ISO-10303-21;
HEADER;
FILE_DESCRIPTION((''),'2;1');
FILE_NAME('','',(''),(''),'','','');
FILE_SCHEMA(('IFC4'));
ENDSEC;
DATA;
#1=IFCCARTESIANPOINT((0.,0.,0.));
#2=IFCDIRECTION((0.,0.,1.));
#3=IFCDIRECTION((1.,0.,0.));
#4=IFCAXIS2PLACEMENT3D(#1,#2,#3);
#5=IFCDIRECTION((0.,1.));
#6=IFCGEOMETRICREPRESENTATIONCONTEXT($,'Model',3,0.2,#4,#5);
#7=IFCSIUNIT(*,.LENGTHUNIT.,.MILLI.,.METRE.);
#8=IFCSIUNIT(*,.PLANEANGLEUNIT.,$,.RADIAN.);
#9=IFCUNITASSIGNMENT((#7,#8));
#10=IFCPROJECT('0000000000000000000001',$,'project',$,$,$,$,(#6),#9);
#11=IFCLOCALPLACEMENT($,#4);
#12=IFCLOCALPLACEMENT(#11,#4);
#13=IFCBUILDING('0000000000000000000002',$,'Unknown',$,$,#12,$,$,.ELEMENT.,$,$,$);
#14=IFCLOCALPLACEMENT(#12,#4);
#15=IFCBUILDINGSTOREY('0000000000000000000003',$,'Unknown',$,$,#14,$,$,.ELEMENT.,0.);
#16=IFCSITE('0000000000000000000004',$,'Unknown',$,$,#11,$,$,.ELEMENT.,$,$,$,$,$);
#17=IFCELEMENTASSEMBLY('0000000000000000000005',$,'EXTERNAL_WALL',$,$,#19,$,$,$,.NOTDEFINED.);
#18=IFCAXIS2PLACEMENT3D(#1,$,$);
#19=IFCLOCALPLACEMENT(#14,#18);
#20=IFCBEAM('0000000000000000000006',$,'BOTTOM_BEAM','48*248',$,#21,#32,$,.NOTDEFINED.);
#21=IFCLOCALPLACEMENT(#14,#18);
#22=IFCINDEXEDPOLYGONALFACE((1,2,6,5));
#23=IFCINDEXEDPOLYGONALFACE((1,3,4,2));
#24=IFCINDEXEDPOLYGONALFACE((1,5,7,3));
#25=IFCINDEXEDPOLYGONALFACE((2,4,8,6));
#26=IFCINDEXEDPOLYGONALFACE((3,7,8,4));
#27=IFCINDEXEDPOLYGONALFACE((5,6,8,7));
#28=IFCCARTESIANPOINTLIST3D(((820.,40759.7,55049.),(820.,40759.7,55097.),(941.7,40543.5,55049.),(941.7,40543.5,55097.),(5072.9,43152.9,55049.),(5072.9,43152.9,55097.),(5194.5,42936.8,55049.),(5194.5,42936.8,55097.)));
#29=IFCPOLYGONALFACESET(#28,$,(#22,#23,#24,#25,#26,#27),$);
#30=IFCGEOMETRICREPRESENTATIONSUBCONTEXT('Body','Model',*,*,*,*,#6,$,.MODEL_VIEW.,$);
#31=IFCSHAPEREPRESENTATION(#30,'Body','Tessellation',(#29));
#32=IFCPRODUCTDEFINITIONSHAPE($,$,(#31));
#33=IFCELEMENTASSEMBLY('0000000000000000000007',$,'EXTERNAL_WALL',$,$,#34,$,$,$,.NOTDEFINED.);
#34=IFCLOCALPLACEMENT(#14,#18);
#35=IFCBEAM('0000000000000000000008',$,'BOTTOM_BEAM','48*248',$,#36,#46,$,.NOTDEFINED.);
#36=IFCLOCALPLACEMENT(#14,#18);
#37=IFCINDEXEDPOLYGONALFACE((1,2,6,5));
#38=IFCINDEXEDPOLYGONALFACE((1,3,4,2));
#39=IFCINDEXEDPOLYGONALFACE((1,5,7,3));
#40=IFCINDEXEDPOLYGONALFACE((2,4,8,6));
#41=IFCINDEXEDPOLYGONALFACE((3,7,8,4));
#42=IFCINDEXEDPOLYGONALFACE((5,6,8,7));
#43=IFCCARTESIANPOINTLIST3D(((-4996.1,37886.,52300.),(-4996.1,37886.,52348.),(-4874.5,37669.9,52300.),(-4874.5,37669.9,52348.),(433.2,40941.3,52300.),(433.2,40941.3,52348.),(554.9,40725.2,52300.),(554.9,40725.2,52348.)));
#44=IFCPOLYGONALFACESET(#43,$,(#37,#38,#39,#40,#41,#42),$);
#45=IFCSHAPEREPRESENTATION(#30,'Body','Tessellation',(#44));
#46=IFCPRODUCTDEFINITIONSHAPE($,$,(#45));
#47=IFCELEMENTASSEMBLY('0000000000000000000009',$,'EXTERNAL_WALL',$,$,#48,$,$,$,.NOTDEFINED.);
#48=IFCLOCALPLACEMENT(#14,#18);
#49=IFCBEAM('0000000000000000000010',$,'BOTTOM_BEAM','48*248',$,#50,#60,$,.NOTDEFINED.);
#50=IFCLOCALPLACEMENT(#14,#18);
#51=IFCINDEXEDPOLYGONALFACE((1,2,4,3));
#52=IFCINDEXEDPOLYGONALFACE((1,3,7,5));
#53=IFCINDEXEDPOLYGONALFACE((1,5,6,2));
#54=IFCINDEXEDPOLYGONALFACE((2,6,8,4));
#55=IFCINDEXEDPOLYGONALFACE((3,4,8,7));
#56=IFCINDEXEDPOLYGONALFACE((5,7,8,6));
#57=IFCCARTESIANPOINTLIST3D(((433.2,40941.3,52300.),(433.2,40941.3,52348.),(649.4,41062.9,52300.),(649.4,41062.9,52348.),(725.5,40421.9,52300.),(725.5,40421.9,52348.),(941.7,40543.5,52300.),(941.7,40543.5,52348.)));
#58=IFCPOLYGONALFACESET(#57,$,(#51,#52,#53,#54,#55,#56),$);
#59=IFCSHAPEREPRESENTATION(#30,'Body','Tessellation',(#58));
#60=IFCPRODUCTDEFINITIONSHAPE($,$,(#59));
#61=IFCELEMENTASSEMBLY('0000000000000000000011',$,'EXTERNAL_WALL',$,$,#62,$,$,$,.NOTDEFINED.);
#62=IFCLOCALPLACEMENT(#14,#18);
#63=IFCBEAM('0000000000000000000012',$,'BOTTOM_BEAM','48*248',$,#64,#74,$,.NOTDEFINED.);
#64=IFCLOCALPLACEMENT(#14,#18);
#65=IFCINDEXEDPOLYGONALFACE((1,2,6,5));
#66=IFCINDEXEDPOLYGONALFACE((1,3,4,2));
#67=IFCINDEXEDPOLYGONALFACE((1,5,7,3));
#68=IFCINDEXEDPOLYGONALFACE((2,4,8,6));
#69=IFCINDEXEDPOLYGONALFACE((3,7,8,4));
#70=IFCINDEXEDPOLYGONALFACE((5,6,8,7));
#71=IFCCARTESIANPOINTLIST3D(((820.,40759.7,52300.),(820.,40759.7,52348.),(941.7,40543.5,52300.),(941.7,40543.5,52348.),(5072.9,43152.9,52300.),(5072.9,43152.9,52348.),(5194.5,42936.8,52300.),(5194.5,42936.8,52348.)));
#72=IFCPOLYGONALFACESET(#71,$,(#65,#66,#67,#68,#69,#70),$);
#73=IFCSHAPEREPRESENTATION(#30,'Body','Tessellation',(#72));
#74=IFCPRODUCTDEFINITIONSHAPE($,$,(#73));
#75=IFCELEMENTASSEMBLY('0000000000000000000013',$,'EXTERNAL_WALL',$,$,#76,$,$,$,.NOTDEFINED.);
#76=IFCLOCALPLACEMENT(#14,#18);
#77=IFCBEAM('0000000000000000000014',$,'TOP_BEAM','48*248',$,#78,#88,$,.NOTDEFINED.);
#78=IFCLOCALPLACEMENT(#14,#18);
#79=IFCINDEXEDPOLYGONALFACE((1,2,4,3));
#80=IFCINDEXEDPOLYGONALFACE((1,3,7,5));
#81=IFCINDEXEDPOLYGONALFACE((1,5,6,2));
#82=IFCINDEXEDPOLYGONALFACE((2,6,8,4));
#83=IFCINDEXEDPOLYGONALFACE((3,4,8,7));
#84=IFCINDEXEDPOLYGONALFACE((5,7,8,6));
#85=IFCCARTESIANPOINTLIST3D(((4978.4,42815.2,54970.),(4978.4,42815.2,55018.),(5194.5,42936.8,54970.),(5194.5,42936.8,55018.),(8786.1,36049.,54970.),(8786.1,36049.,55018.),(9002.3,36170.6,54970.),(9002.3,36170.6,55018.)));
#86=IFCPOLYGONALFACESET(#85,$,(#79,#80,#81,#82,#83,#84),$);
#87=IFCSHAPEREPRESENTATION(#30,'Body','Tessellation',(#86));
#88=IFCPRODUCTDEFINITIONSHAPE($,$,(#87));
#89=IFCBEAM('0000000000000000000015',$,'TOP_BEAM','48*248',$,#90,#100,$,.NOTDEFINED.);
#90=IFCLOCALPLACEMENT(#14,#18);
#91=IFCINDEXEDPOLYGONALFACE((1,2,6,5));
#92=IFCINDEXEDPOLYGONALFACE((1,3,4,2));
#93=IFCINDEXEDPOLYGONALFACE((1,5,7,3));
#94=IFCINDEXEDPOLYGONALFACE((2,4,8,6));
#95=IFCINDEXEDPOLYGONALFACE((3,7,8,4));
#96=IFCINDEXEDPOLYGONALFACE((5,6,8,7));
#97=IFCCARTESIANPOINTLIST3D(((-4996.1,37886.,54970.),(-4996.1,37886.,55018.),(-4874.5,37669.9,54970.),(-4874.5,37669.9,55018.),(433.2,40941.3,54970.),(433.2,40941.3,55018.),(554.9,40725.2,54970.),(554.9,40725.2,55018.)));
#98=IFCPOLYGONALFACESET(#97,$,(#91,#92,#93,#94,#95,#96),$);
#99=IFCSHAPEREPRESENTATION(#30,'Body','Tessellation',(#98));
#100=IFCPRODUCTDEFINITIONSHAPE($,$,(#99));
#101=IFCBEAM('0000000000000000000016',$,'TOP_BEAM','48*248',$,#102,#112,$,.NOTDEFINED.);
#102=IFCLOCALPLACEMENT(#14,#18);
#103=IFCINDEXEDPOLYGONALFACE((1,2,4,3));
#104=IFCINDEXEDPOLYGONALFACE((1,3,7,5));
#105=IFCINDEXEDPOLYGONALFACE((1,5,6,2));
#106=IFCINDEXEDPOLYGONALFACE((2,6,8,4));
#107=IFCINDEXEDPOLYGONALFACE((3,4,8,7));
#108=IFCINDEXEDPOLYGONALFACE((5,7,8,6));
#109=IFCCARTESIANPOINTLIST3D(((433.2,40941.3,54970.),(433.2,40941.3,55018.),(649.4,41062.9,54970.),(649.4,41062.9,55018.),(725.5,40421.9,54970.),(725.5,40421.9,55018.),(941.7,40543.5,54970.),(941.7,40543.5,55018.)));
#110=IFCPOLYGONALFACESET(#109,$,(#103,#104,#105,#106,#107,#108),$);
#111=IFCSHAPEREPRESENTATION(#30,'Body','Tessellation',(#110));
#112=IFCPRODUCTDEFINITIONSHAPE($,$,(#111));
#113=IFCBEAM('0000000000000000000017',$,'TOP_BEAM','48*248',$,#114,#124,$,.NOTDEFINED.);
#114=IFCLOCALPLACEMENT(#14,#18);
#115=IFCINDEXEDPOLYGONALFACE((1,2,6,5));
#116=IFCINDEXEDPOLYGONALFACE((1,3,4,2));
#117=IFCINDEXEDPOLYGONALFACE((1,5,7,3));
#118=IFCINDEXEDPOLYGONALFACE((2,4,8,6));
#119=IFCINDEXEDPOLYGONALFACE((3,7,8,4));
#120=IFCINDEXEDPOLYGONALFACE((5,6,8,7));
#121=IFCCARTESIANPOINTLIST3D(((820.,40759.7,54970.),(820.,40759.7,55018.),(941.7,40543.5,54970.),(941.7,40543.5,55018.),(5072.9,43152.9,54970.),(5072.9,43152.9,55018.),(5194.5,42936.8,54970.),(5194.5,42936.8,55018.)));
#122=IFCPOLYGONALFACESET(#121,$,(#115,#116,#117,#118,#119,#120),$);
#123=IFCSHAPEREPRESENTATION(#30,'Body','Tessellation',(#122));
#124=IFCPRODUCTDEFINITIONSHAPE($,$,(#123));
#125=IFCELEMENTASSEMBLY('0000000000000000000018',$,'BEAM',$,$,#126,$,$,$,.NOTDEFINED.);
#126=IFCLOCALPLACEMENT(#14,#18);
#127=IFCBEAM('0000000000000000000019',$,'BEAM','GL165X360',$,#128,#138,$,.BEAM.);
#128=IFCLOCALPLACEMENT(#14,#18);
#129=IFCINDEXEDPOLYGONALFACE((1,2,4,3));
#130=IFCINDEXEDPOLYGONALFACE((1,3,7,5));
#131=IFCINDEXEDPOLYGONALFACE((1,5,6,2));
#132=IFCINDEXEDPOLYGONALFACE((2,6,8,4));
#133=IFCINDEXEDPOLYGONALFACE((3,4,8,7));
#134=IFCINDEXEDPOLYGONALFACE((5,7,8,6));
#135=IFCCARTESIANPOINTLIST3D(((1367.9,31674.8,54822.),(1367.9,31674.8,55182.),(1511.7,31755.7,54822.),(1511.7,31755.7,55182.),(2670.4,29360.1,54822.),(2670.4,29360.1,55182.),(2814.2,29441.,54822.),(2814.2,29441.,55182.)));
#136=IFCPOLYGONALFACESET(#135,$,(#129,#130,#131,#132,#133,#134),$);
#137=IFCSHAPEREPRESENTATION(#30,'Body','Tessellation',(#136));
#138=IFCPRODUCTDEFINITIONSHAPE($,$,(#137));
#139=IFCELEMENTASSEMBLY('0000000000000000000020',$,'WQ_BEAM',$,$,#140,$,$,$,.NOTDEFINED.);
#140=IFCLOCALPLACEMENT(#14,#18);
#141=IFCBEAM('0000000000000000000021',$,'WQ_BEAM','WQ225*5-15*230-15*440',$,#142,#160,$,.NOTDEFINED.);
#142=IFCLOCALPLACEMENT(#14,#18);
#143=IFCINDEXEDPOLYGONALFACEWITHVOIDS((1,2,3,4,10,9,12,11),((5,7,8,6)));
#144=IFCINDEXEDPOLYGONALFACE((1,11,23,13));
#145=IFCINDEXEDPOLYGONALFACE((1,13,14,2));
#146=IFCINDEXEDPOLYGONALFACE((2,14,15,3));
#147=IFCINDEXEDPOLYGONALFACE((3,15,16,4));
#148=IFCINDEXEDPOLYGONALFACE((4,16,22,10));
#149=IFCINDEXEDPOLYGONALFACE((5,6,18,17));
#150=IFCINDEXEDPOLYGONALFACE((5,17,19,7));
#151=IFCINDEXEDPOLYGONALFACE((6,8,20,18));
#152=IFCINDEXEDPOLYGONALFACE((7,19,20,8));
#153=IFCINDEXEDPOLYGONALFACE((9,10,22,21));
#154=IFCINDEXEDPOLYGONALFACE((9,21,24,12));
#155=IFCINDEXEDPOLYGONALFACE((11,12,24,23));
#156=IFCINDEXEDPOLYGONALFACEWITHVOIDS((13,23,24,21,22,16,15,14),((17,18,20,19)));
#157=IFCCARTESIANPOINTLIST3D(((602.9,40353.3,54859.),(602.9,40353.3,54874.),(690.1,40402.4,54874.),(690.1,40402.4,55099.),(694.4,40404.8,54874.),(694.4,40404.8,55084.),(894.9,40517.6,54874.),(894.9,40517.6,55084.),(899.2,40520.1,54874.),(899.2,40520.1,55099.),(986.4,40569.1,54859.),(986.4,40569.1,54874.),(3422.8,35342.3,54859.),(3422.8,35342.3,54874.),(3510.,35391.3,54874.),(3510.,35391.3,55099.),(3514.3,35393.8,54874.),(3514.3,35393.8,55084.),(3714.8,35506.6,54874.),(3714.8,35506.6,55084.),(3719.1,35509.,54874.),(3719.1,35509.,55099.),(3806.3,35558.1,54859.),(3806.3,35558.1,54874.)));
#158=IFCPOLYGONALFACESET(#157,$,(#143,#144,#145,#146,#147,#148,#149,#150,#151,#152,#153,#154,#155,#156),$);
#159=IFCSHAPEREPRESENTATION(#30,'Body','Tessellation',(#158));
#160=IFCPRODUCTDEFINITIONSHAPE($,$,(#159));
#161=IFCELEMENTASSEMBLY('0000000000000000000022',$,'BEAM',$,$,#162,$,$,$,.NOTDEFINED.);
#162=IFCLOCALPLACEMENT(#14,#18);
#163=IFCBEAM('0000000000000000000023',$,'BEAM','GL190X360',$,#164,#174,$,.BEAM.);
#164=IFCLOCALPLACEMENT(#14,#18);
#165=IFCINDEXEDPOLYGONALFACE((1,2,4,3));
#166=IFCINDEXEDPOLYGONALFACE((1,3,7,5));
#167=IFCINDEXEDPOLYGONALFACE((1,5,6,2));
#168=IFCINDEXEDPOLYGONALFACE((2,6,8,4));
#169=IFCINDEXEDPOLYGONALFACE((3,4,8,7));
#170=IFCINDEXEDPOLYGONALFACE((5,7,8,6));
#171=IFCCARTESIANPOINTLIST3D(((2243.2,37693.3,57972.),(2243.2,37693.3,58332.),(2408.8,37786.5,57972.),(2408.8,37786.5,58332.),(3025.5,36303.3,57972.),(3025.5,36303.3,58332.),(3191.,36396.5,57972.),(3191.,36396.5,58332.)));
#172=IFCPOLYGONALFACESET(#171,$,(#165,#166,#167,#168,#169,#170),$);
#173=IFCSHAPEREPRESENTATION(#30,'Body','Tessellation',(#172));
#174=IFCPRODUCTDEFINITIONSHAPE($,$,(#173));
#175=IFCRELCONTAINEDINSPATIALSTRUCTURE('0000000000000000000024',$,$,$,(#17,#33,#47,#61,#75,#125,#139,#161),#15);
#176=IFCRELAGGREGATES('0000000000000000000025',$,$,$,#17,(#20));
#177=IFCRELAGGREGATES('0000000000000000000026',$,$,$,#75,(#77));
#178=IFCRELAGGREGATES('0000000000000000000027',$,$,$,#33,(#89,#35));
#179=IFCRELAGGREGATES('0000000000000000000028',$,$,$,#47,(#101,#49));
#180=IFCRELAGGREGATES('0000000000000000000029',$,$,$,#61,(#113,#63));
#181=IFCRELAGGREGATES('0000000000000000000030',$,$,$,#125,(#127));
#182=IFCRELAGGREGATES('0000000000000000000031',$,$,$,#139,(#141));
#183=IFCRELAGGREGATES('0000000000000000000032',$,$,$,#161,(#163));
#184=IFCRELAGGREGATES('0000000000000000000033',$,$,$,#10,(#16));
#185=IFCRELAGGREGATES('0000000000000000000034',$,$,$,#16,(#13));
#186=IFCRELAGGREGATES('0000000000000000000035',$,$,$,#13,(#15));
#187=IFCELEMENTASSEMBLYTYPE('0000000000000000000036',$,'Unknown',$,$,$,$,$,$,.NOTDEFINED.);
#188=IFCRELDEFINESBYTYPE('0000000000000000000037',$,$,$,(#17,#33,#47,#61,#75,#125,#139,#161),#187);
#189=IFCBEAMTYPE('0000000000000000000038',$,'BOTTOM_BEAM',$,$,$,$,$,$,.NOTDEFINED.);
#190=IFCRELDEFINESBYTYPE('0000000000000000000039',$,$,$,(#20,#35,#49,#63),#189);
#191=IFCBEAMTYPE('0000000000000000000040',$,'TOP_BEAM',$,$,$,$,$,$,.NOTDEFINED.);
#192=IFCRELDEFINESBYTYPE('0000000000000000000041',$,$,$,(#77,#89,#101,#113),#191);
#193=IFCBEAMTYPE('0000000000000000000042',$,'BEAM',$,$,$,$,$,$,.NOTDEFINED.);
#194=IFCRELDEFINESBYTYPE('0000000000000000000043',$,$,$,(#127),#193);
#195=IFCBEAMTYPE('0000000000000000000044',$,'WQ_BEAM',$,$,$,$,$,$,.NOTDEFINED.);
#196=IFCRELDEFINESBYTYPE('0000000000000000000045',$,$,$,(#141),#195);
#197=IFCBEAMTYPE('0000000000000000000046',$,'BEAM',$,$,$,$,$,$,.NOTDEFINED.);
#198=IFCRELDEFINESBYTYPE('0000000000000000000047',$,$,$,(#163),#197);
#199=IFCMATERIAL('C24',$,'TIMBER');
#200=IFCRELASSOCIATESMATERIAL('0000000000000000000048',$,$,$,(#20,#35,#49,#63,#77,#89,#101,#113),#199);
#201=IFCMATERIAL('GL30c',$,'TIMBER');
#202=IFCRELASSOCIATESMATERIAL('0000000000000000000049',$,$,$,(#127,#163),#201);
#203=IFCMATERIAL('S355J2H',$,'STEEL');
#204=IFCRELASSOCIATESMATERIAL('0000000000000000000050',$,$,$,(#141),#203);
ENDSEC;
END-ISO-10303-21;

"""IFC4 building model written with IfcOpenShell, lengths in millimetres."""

from ifc_helpers import new_model, si_unit, direction, frame, origin_with_axes, origin_2d_with_axis, place, context, subcontext, project, spatial, polyline, rectangle, outline, extrude, material, material_profile, profile_set, profile_usage, type_object, element, aggregate, save


model = new_model("IFC4")

# Units and contexts
model_context = context("Model", 3, precision=0.2, world=origin_with_axes(), true_north=direction((0.0, 1.0)))
body_context = subcontext(model_context, "Body", "Model", "MODEL_VIEW")
ifc_project = project(units=[si_unit("LENGTHUNIT", "METRE", prefix="MILLI"), si_unit("PLANEANGLEUNIT", "RADIAN")], contexts=[model_context])

# Site, building, storey
site_placement = place(None, origin_with_axes())
site = spatial("IfcSite", under=ifc_project, at=site_placement, Name="Unknown", CompositionType="ELEMENT")
building_placement = place(site_placement, origin_with_axes())
building = spatial("IfcBuilding", under=site, at=building_placement, Name="Unknown", CompositionType="ELEMENT")
storey_placement = place(building_placement, origin_with_axes())
storey = spatial("IfcBuildingStorey", under=building, at=storey_placement, Name="Unknown", CompositionType="ELEMENT", Elevation=0.0)

# Shared definitions
element_assembly_type = type_object("IfcElementAssemblyType", Name="Unknown", PredefinedType="NOTDEFINED")

# Shared definitions
ifc_material_1 = material(Name="S355J2H", Category="STEEL")
ifc_material_2 = material(Name="GL30c", Category="TIMBER")

# Element assemblies, beams
ifc_material_3 = material(Name="C24", Category="TIMBER")
ifc_material_profile_1 = material_profile(ifc_material_3, rectangle(XDim=248.0, YDim=48.0, at=origin_2d_with_axis()), Name="48*248")
ifc_profile_set_1 = profile_set([ifc_material_profile_1])
ifc_profile_usage_1 = profile_usage(ifc_profile_set_1, cardinal=3)
beam_type_1 = type_object("IfcBeamType", Name="BOTTOM_BEAM")
assembly_1_placement = place(storey_placement, frame((880.9, 40651.6, 58308.0), z_axis=(0.490421, -0.871485, 0.0), x_axis=(0.871484, 0.490423, 0.0)))
assembly_1 = element("IfcElementAssembly", 1, at=assembly_1_placement, inside=storey, type_object=element_assembly_type, Name="EXTERNAL_WALL", PredefinedType="NOTDEFINED")
beam_1_placement = place(assembly_1_placement, frame((0.0, -3235.0, 0.0), z_axis=(0.0, 0.0, 1.0), x_axis=(1.0, 0.0, 0.0)))
beam_1 = element("IfcBeam", 2, at=beam_1_placement, type_object=beam_type_1, material=ifc_profile_usage_1, Name="BOTTOM_BEAM", Description="48*248", PredefinedType="NOTDEFINED", context=body_context, shape_type="SolidModel", body=[
    extrude(rectangle(XDim=248.0, YDim=48.0, at=origin_2d_with_axis()), frame((0.0, 0.0, 0.0), z_axis=(-1.0, 0.0, 0.0), x_axis=(0.0, 0.0, 1.0)), (0.0, 0.0, -1.0), 4880.0),
])
aggregate(assembly_1, [beam_1])
assembly_2_placement = place(storey_placement, frame((-4935.3, 37777.9, 54994.0), z_axis=(0.490421, -0.871485, 0.0), x_axis=(0.871484, 0.490423, 0.0)))
assembly_2 = element("IfcElementAssembly", 3, at=assembly_2_placement, inside=storey, type_object=element_assembly_type, Name="EXTERNAL_WALL", PredefinedType="NOTDEFINED")
beam_2_placement = place(assembly_2_placement, frame((0.0, -2670.0, 0.0), z_axis=(0.0, 0.0, 1.0), x_axis=(1.0, 0.0, 0.0)))
beam_2 = element("IfcBeam", 4, at=beam_2_placement, type_object=beam_type_1, material=ifc_profile_usage_1, Name="BOTTOM_BEAM", Description="48*248", PredefinedType="NOTDEFINED", context=body_context, shape_type="SolidModel", body=[
    extrude(rectangle(XDim=248.0, YDim=48.0, at=origin_2d_with_axis()), frame((0.0, 0.0, 0.0), z_axis=(-1.0, 0.0, 0.0), x_axis=(0.0, 0.0, 1.0)), (0.0, 0.0, -1.0), 6230.0),
])
assembly_3_placement = place(storey_placement, frame((541.3, 41002.1, 54994.0), z_axis=(-0.871487, -0.490418, 0.0), x_axis=(0.490421, -0.871485, 0.0)))
assembly_3 = element("IfcElementAssembly", 5, at=assembly_3_placement, inside=storey, type_object=element_assembly_type, Name="EXTERNAL_WALL", PredefinedType="NOTDEFINED")
beam_3_placement = place(assembly_3_placement, frame((0.0, -2670.0, 0.0), z_axis=(0.0, 0.0, 1.0), x_axis=(1.0, 0.0, 0.0)))
beam_3 = element("IfcBeam", 6, at=beam_3_placement, type_object=beam_type_1, material=ifc_profile_usage_1, Name="BOTTOM_BEAM", Description="48*248", PredefinedType="NOTDEFINED", context=body_context, shape_type="SolidModel", body=[
    extrude(rectangle(XDim=248.0, YDim=48.0, at=origin_2d_with_axis()), frame((0.0, 0.0, 0.0), z_axis=(-1.0, 0.0, 0.0), x_axis=(0.0, 0.0, 1.0)), (0.0, 0.0, -1.0), 596.0),
])
assembly_4_placement = place(storey_placement, frame((880.9, 40651.6, 54994.0), z_axis=(0.490421, -0.871485, 0.0), x_axis=(0.871484, 0.490423, 0.0)))
assembly_4 = element("IfcElementAssembly", 7, at=assembly_4_placement, inside=storey, type_object=element_assembly_type, Name="EXTERNAL_WALL", PredefinedType="NOTDEFINED")
beam_4_placement = place(assembly_4_placement, frame((0.0, -2670.0, 0.0), z_axis=(0.0, 0.0, 1.0), x_axis=(1.0, 0.0, 0.0)))
beam_4 = element("IfcBeam", 8, at=beam_4_placement, type_object=beam_type_1, material=ifc_profile_usage_1, Name="BOTTOM_BEAM", Description="48*248", PredefinedType="NOTDEFINED", context=body_context, shape_type="SolidModel", body=[
    extrude(rectangle(XDim=248.0, YDim=48.0, at=origin_2d_with_axis()), frame((0.0, 0.0, 0.0), z_axis=(-1.0, 0.0, 0.0), x_axis=(0.0, 0.0, 1.0)), (0.0, 0.0, -1.0), 4880.0),
])
assembly_5_placement = place(storey_placement, frame((5086.5, 42876.0, 54994.0), z_axis=(-0.871477, -0.490436, 0.0), x_axis=(0.490442, -0.871474, 0.0)))
assembly_5 = element("IfcElementAssembly", 9, at=assembly_5_placement, inside=storey, type_object=element_assembly_type, Name="EXTERNAL_WALL", PredefinedType="NOTDEFINED")
beam_type_2 = type_object("IfcBeamType", Name="TOP_BEAM")
beam_5_placement = place(assembly_5_placement, origin_with_axes())
beam_5 = element("IfcBeam", 10, at=beam_5_placement, type_object=beam_type_2, material=ifc_profile_usage_1, Name="TOP_BEAM", Description="48*248", PredefinedType="NOTDEFINED", context=body_context, shape_type="SolidModel", body=[
    extrude(rectangle(XDim=248.0, YDim=48.0, at=origin_2d_with_axis()), frame((0.0, 0.0, 0.0), z_axis=(-1.0, 0.0, 0.0), x_axis=(0.0, 0.0, 1.0)), (0.0, 0.0, -1.0), 7764.0),
])
aggregate(assembly_5, [beam_5])

# Beams
beam_6_placement = place(assembly_2_placement, origin_with_axes())
beam_6 = element("IfcBeam", 11, at=beam_6_placement, type_object=beam_type_2, material=ifc_profile_usage_1, Name="TOP_BEAM", Description="48*248", PredefinedType="NOTDEFINED", context=body_context, shape_type="SolidModel", body=[
    extrude(rectangle(XDim=248.0, YDim=48.0, at=origin_2d_with_axis()), frame((0.0, 0.0, 0.0), z_axis=(-1.0, 0.0, 0.0), x_axis=(0.0, 0.0, 1.0)), (0.0, 0.0, -1.0), 6230.0),
])
aggregate(assembly_2, [beam_6, beam_2])
beam_7_placement = place(assembly_3_placement, origin_with_axes())
beam_7 = element("IfcBeam", 12, at=beam_7_placement, type_object=beam_type_2, material=ifc_profile_usage_1, Name="TOP_BEAM", Description="48*248", PredefinedType="NOTDEFINED", context=body_context, shape_type="SolidModel", body=[
    extrude(rectangle(XDim=248.0, YDim=48.0, at=origin_2d_with_axis()), frame((0.0, 0.0, 0.0), z_axis=(-1.0, 0.0, 0.0), x_axis=(0.0, 0.0, 1.0)), (0.0, 0.0, -1.0), 596.0),
])
aggregate(assembly_3, [beam_7, beam_3])
beam_8_placement = place(assembly_4_placement, origin_with_axes())
beam_8 = element("IfcBeam", 13, at=beam_8_placement, type_object=beam_type_2, material=ifc_profile_usage_1, Name="TOP_BEAM", Description="48*248", PredefinedType="NOTDEFINED", context=body_context, shape_type="SolidModel", body=[
    extrude(rectangle(XDim=248.0, YDim=48.0, at=origin_2d_with_axis()), frame((0.0, 0.0, 0.0), z_axis=(-1.0, 0.0, 0.0), x_axis=(0.0, 0.0, 1.0)), (0.0, 0.0, -1.0), 4880.0),
])
aggregate(assembly_4, [beam_8, beam_4])

# Element assemblies, beams
assembly_6_placement = place(storey_placement, frame((1439.8, 31715.2, 55002.0), z_axis=(-0.871487, -0.490418, 0.0), x_axis=(0.490421, -0.871485, 0.0)))
assembly_6 = element("IfcElementAssembly", 14, at=assembly_6_placement, inside=storey, type_object=element_assembly_type, Name="BEAM", PredefinedType="NOTDEFINED")
ifc_material_profile_2 = material_profile(ifc_material_2, outline(polyline([(-82.5, 180.0), (-82.5, -180.0), (82.5, -180.0), (82.5, 180.0), (-82.5, 180.0)])), Name="GL165X360")
ifc_profile_set_2 = profile_set([ifc_material_profile_2])
ifc_profile_usage_2 = profile_usage(ifc_profile_set_2, cardinal=9)
beam_type_3 = type_object("IfcBeamType", Name="BEAM")
beam_9_placement = place(assembly_6_placement, origin_with_axes())
beam_9 = element("IfcBeam", 15, at=beam_9_placement, type_object=beam_type_3, material=ifc_profile_usage_2, Name="BEAM", Description="GL165X360", PredefinedType="BEAM", context=body_context, shape_type="SolidModel", body=[
    extrude(outline(polyline([(-82.5, 180.0), (-82.5, -180.0), (82.5, -180.0), (82.5, 180.0), (-82.5, 180.0)])), frame((0.0, 0.0, 0.0), z_axis=(-1.0, 0.0, 0.0), x_axis=(0.0, 0.0, 1.0)), (0.0, 0.0, -1.0), 2656.0),
])
aggregate(assembly_6, [beam_9])
assembly_7_placement = place(storey_placement, frame((794.6, 40461.2, 54979.0), z_axis=(-0.871487, -0.490418, 0.0), x_axis=(0.490421, -0.871485, 0.0)))
assembly_7 = element("IfcElementAssembly", 16, at=assembly_7_placement, inside=storey, type_object=element_assembly_type, Name="WQ_BEAM", PredefinedType="NOTDEFINED")
ifc_material_profile_3 = material_profile(ifc_material_1, outline(polyline([(-220.0, -120.0), (220.0, -120.0), (220.0, -105.0), (120.0, -105.0), (120.0, 120.0), (-120.0, 120.0), (-120.0, -105.0), (-220.0, -105.0), (-220.0, -120.0)]), holes=[polyline([(-115.0, -105.0), (-115.0, 105.0), (115.0, 105.0), (115.0, -105.0), (-115.0, -105.0)])]), Name="WQ225*5-15*230-15*440")
ifc_profile_set_3 = profile_set([ifc_material_profile_3])
ifc_profile_usage_3 = profile_usage(ifc_profile_set_3, cardinal=8)
beam_type_4 = type_object("IfcBeamType", Name="WQ_BEAM")
beam_10_placement = place(assembly_7_placement, origin_with_axes())
beam_10 = element("IfcBeam", 17, at=beam_10_placement, type_object=beam_type_4, material=ifc_profile_usage_3, Name="WQ_BEAM", Description="WQ225*5-15*230-15*440", PredefinedType="NOTDEFINED", context=body_context, shape_type="SolidModel", body=[
    extrude(outline(polyline([(-220.0, -120.0), (220.0, -120.0), (220.0, -105.0), (120.0, -105.0), (120.0, 120.0), (-120.0, 120.0), (-120.0, -105.0), (-220.0, -105.0), (-220.0, -120.0)]), holes=[polyline([(-115.0, -105.0), (-115.0, 105.0), (115.0, 105.0), (115.0, -105.0), (-115.0, -105.0)])]), frame((0.0, 0.0, 0.0), z_axis=(-1.0, 0.0, 0.0), x_axis=(0.0, 0.0, 1.0)), (0.0, 0.0, -1.0), 5750.0),
])
aggregate(assembly_7, [beam_10])
assembly_8_placement = place(storey_placement, frame((2326.0, 37739.9, 58152.0), z_axis=(-0.871487, -0.490418, 0.0), x_axis=(0.490421, -0.871485, 0.0)))
assembly_8 = element("IfcElementAssembly", 18, at=assembly_8_placement, inside=storey, type_object=element_assembly_type, Name="BEAM", PredefinedType="NOTDEFINED")
ifc_material_profile_4 = material_profile(ifc_material_2, outline(polyline([(-95.0, 180.0), (-95.0, -180.0), (95.0, -180.0), (95.0, 180.0), (-95.0, 180.0)])), Name="GL190X360")
ifc_profile_set_4 = profile_set([ifc_material_profile_4])
ifc_profile_usage_4 = profile_usage(ifc_profile_set_4, cardinal=8)
beam_type_5 = type_object("IfcBeamType", Name="BEAM")
beam_11_placement = place(assembly_8_placement, origin_with_axes())
beam_11 = element("IfcBeam", 19, at=beam_11_placement, type_object=beam_type_5, material=ifc_profile_usage_4, Name="BEAM", Description="GL190X360", PredefinedType="BEAM", context=body_context, shape_type="SolidModel", body=[
    extrude(outline(polyline([(-95.0, 180.0), (-95.0, -180.0), (95.0, -180.0), (95.0, 180.0), (-95.0, 180.0)])), frame((0.0, 0.0, 0.0), z_axis=(-1.0, 0.0, 0.0), x_axis=(0.0, 0.0, 1.0)), (0.0, 0.0, -1.0), 1595.0),
])
aggregate(assembly_8, [beam_11])

save(model, "model.ifc")
